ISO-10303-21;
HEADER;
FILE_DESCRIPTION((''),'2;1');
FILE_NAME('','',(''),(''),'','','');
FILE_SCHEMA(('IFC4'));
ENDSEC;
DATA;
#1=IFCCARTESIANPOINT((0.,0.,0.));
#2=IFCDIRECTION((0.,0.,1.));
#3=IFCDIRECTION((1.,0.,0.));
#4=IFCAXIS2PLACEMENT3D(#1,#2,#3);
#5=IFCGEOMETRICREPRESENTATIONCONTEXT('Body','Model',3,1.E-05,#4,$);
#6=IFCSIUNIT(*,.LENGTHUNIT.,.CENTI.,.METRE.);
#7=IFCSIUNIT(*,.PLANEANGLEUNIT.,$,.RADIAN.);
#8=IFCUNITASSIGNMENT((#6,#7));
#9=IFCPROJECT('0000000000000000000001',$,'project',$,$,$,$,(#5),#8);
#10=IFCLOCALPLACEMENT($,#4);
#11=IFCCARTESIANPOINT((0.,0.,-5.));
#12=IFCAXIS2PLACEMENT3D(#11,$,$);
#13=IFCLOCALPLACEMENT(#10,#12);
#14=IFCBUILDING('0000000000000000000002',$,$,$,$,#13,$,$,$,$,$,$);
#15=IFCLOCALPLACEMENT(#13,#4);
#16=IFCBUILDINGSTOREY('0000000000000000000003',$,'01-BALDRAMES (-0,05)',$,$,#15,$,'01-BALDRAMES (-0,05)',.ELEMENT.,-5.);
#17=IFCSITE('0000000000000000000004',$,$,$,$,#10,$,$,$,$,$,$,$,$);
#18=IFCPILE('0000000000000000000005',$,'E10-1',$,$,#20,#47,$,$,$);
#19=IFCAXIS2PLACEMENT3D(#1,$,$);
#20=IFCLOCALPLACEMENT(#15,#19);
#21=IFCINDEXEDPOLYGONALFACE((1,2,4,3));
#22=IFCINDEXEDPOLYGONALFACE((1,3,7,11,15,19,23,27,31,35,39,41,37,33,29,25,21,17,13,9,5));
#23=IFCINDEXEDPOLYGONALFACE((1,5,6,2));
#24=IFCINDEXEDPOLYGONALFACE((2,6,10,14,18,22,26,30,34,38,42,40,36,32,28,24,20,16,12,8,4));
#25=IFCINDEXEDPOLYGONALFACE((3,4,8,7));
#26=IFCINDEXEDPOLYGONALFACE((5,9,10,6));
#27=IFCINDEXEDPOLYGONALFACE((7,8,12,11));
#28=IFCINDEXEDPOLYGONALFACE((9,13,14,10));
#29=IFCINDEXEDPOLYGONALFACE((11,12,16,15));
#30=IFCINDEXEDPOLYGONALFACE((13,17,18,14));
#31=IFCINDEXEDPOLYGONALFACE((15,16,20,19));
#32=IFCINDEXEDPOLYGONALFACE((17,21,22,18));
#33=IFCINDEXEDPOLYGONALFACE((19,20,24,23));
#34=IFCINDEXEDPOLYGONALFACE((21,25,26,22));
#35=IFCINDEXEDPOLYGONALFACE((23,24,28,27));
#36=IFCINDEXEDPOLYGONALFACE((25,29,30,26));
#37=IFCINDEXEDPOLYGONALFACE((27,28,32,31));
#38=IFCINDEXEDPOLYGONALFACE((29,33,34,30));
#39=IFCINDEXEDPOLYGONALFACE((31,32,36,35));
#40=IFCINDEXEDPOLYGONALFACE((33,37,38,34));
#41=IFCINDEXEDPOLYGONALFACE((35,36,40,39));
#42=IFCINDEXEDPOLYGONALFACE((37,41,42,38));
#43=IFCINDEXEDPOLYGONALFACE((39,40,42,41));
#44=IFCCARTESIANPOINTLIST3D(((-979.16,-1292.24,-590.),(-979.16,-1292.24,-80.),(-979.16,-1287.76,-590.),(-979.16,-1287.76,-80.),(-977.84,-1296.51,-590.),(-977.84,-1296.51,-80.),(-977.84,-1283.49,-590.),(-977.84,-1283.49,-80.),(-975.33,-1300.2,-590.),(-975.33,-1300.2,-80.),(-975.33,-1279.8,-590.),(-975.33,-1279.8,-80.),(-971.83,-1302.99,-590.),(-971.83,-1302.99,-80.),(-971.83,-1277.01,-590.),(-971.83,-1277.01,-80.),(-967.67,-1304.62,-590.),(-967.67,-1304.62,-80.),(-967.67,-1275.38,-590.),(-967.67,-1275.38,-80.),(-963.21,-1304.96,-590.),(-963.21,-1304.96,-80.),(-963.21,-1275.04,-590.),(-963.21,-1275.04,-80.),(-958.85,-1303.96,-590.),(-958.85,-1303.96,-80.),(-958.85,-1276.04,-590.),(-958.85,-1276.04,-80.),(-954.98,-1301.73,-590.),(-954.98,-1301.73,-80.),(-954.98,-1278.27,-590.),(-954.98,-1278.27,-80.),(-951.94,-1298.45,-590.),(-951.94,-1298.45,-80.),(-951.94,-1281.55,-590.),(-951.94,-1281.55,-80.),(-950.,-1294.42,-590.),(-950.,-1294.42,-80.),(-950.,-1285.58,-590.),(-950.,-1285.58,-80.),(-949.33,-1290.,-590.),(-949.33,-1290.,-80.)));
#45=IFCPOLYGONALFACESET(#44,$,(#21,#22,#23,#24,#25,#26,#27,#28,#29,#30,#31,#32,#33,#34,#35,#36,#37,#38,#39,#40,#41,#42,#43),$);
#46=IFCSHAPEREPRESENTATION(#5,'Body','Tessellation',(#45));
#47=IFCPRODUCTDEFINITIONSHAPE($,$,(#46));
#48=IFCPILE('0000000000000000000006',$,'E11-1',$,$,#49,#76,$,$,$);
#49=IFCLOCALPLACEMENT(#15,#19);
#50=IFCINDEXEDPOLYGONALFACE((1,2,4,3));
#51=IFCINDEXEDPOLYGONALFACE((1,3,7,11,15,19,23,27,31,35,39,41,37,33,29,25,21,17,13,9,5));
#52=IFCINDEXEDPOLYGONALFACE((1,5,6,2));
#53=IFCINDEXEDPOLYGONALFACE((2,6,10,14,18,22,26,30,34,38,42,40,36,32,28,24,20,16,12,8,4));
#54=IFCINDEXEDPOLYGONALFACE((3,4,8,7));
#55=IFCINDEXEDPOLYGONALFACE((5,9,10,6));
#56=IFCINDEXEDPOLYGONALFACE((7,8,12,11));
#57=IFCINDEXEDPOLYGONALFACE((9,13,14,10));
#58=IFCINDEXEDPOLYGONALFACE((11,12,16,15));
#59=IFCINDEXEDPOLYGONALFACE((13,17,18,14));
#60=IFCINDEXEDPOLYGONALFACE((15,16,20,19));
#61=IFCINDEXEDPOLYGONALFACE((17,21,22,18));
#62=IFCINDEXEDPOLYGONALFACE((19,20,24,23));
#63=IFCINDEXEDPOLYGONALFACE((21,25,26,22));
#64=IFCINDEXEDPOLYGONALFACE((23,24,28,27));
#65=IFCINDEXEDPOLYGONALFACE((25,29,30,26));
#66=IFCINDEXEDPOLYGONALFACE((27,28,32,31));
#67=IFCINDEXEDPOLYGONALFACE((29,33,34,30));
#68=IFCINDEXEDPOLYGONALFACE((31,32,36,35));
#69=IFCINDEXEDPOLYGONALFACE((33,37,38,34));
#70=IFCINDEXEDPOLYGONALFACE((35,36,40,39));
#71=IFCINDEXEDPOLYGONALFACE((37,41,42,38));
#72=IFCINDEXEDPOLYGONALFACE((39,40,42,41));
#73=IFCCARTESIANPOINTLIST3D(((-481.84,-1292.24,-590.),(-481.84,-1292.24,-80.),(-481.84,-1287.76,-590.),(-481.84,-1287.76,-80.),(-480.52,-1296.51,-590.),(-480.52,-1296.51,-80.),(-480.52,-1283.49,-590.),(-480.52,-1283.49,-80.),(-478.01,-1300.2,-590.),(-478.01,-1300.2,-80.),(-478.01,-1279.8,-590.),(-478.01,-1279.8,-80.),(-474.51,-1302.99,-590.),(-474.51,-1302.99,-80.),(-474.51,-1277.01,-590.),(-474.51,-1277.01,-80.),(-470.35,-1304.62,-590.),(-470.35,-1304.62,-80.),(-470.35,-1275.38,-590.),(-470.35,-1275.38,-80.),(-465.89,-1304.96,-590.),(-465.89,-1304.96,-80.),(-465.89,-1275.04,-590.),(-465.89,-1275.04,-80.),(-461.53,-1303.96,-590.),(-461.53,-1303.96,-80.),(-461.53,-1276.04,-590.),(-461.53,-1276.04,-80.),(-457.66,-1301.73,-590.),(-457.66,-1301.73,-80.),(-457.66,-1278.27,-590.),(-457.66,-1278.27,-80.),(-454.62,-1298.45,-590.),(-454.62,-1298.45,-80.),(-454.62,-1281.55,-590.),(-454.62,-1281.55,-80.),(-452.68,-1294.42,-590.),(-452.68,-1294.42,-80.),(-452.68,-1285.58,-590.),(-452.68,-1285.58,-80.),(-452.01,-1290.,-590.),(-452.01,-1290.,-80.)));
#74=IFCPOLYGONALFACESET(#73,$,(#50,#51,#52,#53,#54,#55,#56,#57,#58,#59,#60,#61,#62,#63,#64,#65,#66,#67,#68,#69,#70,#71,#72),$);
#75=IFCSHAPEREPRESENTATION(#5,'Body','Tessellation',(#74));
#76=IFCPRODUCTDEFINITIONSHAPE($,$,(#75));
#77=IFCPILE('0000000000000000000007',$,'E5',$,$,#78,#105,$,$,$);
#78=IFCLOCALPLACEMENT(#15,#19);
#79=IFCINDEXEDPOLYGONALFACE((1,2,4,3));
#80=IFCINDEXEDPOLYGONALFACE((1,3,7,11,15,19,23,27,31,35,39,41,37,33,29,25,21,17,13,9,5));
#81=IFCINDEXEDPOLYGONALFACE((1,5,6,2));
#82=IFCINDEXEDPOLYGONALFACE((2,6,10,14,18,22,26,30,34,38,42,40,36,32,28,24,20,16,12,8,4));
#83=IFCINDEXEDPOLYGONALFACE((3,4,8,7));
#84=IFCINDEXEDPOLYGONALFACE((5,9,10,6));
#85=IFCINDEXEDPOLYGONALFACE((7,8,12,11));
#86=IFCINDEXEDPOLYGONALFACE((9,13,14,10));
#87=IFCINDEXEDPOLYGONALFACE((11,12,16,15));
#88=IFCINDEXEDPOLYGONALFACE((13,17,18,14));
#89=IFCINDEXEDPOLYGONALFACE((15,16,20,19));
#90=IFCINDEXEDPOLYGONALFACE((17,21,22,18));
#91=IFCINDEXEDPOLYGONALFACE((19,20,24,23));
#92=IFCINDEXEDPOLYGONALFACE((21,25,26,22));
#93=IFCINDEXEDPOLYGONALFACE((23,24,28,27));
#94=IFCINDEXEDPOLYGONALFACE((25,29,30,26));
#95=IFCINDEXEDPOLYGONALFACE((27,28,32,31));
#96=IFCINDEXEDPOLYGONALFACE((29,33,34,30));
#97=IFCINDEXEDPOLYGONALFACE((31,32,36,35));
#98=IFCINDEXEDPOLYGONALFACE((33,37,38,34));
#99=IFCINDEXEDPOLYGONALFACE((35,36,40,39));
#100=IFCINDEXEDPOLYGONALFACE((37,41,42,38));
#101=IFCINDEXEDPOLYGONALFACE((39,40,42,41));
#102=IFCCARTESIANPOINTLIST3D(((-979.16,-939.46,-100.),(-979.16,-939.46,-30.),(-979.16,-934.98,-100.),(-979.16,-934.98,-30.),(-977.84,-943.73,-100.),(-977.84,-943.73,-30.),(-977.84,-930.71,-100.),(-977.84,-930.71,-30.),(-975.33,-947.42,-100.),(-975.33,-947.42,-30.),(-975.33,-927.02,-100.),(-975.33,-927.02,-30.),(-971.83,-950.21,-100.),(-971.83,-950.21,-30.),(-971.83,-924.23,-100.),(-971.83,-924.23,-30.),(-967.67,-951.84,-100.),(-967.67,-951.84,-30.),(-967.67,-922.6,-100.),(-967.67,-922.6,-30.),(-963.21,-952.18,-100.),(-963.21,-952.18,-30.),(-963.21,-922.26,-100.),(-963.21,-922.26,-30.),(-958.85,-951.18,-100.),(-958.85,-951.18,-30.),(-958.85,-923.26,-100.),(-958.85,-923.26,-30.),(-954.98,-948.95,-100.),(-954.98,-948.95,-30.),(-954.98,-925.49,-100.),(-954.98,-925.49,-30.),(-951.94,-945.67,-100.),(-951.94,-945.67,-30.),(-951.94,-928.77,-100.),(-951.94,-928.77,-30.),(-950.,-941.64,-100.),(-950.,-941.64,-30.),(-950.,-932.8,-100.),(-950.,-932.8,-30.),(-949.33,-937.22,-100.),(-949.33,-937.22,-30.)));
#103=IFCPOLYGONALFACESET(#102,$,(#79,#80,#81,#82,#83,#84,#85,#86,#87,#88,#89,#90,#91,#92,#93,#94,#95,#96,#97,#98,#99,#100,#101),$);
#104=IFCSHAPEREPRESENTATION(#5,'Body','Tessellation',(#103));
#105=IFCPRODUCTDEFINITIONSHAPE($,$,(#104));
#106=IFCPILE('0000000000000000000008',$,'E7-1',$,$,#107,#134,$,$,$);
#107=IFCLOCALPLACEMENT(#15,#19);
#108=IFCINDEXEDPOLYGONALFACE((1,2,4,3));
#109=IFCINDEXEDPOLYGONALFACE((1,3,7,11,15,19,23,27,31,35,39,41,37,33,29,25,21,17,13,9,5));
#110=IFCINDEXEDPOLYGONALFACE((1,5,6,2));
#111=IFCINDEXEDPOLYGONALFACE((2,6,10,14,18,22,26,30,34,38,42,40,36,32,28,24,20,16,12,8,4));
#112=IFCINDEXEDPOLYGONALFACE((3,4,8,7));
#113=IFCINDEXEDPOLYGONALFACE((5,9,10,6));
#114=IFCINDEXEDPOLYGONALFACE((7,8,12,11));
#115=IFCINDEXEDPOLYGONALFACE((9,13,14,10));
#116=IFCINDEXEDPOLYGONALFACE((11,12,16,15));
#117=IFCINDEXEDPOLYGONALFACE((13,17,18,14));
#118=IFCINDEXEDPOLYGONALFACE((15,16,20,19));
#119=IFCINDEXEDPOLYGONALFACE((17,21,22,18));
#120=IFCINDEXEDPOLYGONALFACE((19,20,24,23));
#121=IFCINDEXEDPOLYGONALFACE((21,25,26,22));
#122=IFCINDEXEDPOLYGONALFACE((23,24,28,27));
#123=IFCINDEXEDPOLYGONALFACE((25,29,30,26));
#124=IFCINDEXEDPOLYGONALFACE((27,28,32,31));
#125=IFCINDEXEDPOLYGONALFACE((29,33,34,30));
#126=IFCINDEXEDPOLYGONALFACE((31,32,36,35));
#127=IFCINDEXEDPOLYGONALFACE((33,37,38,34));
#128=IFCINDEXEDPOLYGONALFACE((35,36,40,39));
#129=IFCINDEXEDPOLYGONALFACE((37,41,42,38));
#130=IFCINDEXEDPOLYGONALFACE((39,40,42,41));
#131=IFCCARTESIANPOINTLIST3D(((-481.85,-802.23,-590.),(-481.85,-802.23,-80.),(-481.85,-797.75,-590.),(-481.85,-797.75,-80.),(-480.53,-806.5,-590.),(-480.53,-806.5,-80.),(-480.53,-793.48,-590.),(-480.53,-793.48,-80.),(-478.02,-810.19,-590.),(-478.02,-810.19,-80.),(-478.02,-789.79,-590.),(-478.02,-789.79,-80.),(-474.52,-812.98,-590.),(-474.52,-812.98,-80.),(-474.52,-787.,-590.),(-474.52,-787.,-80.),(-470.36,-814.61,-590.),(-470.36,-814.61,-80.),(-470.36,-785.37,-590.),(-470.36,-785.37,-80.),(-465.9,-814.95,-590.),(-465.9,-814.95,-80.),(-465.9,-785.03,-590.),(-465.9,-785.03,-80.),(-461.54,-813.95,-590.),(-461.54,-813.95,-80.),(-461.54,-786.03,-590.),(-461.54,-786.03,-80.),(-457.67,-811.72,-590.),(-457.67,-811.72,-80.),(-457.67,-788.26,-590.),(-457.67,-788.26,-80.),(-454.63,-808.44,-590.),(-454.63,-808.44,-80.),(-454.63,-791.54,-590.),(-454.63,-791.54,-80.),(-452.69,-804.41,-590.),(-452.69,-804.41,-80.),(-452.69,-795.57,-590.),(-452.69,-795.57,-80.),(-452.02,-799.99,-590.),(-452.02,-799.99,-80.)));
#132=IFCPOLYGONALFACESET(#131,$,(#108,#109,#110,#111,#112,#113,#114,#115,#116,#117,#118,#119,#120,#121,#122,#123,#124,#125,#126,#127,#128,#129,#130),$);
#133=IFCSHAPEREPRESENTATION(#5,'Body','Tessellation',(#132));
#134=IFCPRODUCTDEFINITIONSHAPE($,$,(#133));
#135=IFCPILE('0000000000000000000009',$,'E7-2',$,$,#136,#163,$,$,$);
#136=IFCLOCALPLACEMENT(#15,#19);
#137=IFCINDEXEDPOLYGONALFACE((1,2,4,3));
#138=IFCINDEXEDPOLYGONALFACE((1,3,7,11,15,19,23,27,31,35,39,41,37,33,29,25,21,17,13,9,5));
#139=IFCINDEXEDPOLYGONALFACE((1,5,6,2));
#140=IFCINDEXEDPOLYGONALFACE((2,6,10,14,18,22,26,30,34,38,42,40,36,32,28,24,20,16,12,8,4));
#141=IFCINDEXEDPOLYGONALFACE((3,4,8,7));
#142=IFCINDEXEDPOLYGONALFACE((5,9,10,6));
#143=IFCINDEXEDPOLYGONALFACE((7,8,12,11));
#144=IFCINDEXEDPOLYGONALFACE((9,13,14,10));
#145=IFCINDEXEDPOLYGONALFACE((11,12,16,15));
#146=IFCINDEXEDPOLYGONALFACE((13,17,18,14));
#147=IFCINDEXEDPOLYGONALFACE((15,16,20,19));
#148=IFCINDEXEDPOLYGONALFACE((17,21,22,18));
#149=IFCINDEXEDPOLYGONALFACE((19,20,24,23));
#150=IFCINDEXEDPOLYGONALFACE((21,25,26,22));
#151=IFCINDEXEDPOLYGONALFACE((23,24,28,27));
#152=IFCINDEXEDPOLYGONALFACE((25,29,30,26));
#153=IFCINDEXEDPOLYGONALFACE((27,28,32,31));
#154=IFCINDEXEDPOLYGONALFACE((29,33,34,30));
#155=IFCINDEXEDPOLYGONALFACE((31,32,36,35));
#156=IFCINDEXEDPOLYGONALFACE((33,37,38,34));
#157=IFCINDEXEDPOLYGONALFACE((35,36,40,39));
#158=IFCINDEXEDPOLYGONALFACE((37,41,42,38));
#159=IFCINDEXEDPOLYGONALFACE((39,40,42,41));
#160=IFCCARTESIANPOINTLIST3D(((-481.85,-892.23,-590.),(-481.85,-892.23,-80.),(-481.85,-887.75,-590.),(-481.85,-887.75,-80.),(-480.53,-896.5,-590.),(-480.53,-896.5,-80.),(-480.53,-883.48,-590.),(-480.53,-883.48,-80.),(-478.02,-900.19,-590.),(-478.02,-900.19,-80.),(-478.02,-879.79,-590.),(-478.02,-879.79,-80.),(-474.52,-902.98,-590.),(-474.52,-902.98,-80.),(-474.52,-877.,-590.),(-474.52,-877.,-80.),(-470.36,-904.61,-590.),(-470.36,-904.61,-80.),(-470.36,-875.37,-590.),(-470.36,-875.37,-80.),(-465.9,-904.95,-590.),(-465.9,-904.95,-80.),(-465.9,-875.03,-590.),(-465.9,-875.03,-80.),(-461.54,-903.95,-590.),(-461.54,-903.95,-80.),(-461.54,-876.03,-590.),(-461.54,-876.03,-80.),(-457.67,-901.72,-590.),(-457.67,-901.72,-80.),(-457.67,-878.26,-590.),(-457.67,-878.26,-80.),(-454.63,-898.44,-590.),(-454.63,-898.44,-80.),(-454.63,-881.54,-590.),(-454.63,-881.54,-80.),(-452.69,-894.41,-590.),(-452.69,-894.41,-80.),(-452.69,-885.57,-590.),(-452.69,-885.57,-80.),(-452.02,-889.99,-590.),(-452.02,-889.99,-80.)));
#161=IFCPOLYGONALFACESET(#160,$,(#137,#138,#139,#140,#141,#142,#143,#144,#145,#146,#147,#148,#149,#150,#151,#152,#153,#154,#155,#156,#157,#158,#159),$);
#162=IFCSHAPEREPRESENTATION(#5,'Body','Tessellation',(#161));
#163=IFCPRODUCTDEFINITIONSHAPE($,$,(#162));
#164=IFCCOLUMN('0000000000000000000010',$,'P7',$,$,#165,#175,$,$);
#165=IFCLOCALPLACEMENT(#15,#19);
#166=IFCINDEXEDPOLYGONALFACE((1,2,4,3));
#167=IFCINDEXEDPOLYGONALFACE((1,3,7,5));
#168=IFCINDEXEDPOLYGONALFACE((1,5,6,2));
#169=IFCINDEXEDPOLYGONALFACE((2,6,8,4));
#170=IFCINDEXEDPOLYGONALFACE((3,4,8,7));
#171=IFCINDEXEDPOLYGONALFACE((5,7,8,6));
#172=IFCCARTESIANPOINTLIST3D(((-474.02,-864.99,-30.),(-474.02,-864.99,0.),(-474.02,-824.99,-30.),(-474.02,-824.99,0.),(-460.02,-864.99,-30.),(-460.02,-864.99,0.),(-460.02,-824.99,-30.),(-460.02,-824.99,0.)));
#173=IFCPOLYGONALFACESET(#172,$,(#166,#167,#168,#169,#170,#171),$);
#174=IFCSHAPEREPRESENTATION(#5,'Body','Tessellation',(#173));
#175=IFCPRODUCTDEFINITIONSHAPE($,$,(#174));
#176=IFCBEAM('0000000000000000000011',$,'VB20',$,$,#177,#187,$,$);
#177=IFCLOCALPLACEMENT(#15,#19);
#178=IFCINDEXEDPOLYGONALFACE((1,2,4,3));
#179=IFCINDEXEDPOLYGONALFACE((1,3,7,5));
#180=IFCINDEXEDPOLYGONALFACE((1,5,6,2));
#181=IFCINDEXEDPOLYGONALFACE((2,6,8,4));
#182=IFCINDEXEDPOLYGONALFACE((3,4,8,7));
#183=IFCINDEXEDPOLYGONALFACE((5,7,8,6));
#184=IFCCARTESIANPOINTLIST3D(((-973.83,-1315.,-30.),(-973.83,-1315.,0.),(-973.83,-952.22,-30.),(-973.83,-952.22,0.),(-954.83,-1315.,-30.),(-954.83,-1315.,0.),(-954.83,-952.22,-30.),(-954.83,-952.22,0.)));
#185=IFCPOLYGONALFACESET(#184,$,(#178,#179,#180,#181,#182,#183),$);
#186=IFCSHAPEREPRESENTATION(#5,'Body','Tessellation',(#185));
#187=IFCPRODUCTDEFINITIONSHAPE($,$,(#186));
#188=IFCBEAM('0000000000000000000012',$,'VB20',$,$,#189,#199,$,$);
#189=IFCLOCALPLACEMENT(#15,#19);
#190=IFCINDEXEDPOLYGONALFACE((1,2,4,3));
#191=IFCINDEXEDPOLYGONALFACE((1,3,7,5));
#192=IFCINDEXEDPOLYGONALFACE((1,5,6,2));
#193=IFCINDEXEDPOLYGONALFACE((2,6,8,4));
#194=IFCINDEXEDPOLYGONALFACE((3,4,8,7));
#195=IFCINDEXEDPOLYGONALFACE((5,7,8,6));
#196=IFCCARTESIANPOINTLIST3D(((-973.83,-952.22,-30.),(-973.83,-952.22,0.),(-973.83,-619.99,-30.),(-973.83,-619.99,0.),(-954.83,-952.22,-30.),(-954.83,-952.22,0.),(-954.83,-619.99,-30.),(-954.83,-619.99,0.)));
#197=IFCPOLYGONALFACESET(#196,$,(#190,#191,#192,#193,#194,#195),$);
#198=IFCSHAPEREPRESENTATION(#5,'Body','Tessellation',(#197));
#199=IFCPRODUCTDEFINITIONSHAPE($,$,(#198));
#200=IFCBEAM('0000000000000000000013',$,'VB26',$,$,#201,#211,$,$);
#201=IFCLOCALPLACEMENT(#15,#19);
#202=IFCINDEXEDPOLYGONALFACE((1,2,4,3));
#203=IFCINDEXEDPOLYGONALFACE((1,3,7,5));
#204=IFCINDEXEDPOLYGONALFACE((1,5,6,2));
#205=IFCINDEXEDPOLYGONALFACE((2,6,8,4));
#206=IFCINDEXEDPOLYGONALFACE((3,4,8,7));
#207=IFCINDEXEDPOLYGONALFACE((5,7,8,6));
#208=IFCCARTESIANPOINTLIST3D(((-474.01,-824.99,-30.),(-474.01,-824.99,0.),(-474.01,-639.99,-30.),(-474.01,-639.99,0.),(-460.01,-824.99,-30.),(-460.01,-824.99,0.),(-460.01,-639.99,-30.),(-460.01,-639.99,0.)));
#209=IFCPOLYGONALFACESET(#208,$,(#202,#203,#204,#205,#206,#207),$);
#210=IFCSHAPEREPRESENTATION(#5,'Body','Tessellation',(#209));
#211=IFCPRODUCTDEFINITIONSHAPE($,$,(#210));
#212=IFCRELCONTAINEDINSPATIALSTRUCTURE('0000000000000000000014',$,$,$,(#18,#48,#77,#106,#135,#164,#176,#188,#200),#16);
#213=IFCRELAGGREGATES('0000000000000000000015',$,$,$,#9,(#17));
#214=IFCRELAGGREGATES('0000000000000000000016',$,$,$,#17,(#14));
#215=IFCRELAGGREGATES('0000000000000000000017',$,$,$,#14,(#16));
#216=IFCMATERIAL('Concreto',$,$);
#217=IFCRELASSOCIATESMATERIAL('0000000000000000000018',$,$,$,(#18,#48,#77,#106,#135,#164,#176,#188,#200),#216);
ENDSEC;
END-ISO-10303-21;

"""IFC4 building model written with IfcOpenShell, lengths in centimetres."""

from ifc_helpers import new_model, si_unit, frame, origin_with_axes, origin_2d_with_axis, place, context, project, spatial, rectangle, circle, extrude, material, element, save


model = new_model("IFC4")

# Units and contexts
model_context = context("Model", 3, precision=1e-05, world=origin_with_axes(), identifier="Body")
ifc_project = project(units=[si_unit("LENGTHUNIT", "METRE", prefix="CENTI"), si_unit("PLANEANGLEUNIT", "RADIAN")], contexts=[model_context])

# Site, building, storey
site_placement = place(None, origin_with_axes())
site = spatial("IfcSite", under=ifc_project, at=site_placement)
building_placement = place(site_placement, frame((0.0, 0.0, -5.0)))
building = spatial("IfcBuilding", under=site, at=building_placement)
storey_placement = place(building_placement, origin_with_axes())
storey = spatial("IfcBuildingStorey", under=building, at=storey_placement, Name="01-BALDRAMES (-0,05)", LongName="01-BALDRAMES (-0,05)", CompositionType="ELEMENT", Elevation=-5.0)

# Piles
ifc_material = material(Name="Concreto")
for number, where, z_axis, x_axis, name in (
    (1, (-964.33, -1290.0, -80.0), (0.0, 0.0, 1.0), (1.0, 0.0, 0.0), "E10-1"),
    (2, (-467.01, -1290.0, -80.0), (0.0, 0.0, 1.0), (1.0, 0.0, 0.0), "E11-1"),
):
    element("IfcPile", number, at=place(storey_placement, frame(where, z_axis=z_axis, x_axis=x_axis)), inside=storey, material=ifc_material, Name=name, context=model_context, shape_type="SweptSolid", body=[
        extrude(circle(Radius=15.0, at=origin_2d_with_axis()), frame((0.0, 0.0, -510.0), z_axis=(0.0, 0.0, 1.0), x_axis=(1.0, 0.0, 0.0)), (0.0, 0.0, 1.0), 510.0),
    ])
pile_placement = place(storey_placement, frame((-964.33, -937.22, -30.0), z_axis=(0.0, 0.0, 1.0), x_axis=(1.0, 0.0, 0.0)))
element("IfcPile", 3, at=pile_placement, inside=storey, material=ifc_material, Name="E5", context=model_context, shape_type="SolidModel", body=[
    extrude(circle(Radius=15.0, at=origin_2d_with_axis()), frame((0.0, 0.0, -70.0), z_axis=(0.0, 0.0, 1.0), x_axis=(1.0, 0.0, 0.0)), (0.0, 0.0, 1.0), 70.0),
])
for number, where, z_axis, x_axis, name in (
    (4, (-467.02, -799.99, -80.0), (0.0, 0.0, 1.0), (1.0, 0.0, 0.0), "E7-1"),
    (5, (-467.02, -889.99, -80.0), (0.0, 0.0, 1.0), (1.0, 0.0, 0.0), "E7-2"),
):
    element("IfcPile", number, at=place(storey_placement, frame(where, z_axis=z_axis, x_axis=x_axis)), inside=storey, material=ifc_material, Name=name, context=model_context, shape_type="SweptSolid", body=[
        extrude(circle(Radius=15.0, at=origin_2d_with_axis()), frame((0.0, 0.0, -510.0), z_axis=(0.0, 0.0, 1.0), x_axis=(1.0, 0.0, 0.0)), (0.0, 0.0, 1.0), 510.0),
    ])

# Column
column_placement = place(storey_placement, frame((-467.02, -844.99, 0.0), z_axis=(0.0, 0.0, 1.0), x_axis=(1.0, 0.0, 0.0)))
element("IfcColumn", 6, at=column_placement, inside=storey, material=ifc_material, Name="P7", context=model_context, shape_type="SolidModel", body=[
    extrude(rectangle(XDim=14.0, YDim=40.0, at=origin_2d_with_axis()), origin_with_axes(), (0.0, 0.0, -1.0), 30.0),
])

# Beams
beam_1_placement = place(storey_placement, frame((-964.33, -1133.61, 0.0), z_axis=(0.0, 0.0, 1.0), x_axis=(1.0, 0.0, 0.0)))
element("IfcBeam", 7, at=beam_1_placement, inside=storey, material=ifc_material, Name="VB20", context=model_context, shape_type="SolidModel", body=[
    extrude(rectangle(XDim=19.0, YDim=30.0, at=origin_2d_with_axis()), frame((0.0, -181.39, -15.0), z_axis=(0.0, 1.0, 0.0), x_axis=(-1.0, 0.0, 0.0)), (0.0, 0.0, 1.0), 362.78),
])
beam_2_placement = place(storey_placement, frame((-964.33, -786.11, 0.0), z_axis=(0.0, 0.0, 1.0), x_axis=(1.0, 0.0, 0.0)))
element("IfcBeam", 8, at=beam_2_placement, inside=storey, material=ifc_material, Name="VB20", context=model_context, shape_type="SolidModel", body=[
    extrude(rectangle(XDim=19.0, YDim=30.0, at=origin_2d_with_axis()), frame((0.0, -166.12, -15.0), z_axis=(0.0, 1.0, 0.0), x_axis=(-1.0, 0.0, 0.0)), (0.0, 0.0, 1.0), 332.23),
])
beam_3_placement = place(storey_placement, frame((-467.01, -732.49, 0.0), z_axis=(0.0, 0.0, 1.0), x_axis=(1.0, 0.0, 0.0)))
element("IfcBeam", 9, at=beam_3_placement, inside=storey, material=ifc_material, Name="VB26", context=model_context, shape_type="SolidModel", body=[
    extrude(rectangle(XDim=14.0, YDim=30.0, at=origin_2d_with_axis()), frame((0.0, -92.5, -15.0), z_axis=(0.0, 1.0, 0.0), x_axis=(1.0, 0.0, 0.0)), (0.0, 0.0, 1.0), 185.0),
])

save(model, "model.ifc")
